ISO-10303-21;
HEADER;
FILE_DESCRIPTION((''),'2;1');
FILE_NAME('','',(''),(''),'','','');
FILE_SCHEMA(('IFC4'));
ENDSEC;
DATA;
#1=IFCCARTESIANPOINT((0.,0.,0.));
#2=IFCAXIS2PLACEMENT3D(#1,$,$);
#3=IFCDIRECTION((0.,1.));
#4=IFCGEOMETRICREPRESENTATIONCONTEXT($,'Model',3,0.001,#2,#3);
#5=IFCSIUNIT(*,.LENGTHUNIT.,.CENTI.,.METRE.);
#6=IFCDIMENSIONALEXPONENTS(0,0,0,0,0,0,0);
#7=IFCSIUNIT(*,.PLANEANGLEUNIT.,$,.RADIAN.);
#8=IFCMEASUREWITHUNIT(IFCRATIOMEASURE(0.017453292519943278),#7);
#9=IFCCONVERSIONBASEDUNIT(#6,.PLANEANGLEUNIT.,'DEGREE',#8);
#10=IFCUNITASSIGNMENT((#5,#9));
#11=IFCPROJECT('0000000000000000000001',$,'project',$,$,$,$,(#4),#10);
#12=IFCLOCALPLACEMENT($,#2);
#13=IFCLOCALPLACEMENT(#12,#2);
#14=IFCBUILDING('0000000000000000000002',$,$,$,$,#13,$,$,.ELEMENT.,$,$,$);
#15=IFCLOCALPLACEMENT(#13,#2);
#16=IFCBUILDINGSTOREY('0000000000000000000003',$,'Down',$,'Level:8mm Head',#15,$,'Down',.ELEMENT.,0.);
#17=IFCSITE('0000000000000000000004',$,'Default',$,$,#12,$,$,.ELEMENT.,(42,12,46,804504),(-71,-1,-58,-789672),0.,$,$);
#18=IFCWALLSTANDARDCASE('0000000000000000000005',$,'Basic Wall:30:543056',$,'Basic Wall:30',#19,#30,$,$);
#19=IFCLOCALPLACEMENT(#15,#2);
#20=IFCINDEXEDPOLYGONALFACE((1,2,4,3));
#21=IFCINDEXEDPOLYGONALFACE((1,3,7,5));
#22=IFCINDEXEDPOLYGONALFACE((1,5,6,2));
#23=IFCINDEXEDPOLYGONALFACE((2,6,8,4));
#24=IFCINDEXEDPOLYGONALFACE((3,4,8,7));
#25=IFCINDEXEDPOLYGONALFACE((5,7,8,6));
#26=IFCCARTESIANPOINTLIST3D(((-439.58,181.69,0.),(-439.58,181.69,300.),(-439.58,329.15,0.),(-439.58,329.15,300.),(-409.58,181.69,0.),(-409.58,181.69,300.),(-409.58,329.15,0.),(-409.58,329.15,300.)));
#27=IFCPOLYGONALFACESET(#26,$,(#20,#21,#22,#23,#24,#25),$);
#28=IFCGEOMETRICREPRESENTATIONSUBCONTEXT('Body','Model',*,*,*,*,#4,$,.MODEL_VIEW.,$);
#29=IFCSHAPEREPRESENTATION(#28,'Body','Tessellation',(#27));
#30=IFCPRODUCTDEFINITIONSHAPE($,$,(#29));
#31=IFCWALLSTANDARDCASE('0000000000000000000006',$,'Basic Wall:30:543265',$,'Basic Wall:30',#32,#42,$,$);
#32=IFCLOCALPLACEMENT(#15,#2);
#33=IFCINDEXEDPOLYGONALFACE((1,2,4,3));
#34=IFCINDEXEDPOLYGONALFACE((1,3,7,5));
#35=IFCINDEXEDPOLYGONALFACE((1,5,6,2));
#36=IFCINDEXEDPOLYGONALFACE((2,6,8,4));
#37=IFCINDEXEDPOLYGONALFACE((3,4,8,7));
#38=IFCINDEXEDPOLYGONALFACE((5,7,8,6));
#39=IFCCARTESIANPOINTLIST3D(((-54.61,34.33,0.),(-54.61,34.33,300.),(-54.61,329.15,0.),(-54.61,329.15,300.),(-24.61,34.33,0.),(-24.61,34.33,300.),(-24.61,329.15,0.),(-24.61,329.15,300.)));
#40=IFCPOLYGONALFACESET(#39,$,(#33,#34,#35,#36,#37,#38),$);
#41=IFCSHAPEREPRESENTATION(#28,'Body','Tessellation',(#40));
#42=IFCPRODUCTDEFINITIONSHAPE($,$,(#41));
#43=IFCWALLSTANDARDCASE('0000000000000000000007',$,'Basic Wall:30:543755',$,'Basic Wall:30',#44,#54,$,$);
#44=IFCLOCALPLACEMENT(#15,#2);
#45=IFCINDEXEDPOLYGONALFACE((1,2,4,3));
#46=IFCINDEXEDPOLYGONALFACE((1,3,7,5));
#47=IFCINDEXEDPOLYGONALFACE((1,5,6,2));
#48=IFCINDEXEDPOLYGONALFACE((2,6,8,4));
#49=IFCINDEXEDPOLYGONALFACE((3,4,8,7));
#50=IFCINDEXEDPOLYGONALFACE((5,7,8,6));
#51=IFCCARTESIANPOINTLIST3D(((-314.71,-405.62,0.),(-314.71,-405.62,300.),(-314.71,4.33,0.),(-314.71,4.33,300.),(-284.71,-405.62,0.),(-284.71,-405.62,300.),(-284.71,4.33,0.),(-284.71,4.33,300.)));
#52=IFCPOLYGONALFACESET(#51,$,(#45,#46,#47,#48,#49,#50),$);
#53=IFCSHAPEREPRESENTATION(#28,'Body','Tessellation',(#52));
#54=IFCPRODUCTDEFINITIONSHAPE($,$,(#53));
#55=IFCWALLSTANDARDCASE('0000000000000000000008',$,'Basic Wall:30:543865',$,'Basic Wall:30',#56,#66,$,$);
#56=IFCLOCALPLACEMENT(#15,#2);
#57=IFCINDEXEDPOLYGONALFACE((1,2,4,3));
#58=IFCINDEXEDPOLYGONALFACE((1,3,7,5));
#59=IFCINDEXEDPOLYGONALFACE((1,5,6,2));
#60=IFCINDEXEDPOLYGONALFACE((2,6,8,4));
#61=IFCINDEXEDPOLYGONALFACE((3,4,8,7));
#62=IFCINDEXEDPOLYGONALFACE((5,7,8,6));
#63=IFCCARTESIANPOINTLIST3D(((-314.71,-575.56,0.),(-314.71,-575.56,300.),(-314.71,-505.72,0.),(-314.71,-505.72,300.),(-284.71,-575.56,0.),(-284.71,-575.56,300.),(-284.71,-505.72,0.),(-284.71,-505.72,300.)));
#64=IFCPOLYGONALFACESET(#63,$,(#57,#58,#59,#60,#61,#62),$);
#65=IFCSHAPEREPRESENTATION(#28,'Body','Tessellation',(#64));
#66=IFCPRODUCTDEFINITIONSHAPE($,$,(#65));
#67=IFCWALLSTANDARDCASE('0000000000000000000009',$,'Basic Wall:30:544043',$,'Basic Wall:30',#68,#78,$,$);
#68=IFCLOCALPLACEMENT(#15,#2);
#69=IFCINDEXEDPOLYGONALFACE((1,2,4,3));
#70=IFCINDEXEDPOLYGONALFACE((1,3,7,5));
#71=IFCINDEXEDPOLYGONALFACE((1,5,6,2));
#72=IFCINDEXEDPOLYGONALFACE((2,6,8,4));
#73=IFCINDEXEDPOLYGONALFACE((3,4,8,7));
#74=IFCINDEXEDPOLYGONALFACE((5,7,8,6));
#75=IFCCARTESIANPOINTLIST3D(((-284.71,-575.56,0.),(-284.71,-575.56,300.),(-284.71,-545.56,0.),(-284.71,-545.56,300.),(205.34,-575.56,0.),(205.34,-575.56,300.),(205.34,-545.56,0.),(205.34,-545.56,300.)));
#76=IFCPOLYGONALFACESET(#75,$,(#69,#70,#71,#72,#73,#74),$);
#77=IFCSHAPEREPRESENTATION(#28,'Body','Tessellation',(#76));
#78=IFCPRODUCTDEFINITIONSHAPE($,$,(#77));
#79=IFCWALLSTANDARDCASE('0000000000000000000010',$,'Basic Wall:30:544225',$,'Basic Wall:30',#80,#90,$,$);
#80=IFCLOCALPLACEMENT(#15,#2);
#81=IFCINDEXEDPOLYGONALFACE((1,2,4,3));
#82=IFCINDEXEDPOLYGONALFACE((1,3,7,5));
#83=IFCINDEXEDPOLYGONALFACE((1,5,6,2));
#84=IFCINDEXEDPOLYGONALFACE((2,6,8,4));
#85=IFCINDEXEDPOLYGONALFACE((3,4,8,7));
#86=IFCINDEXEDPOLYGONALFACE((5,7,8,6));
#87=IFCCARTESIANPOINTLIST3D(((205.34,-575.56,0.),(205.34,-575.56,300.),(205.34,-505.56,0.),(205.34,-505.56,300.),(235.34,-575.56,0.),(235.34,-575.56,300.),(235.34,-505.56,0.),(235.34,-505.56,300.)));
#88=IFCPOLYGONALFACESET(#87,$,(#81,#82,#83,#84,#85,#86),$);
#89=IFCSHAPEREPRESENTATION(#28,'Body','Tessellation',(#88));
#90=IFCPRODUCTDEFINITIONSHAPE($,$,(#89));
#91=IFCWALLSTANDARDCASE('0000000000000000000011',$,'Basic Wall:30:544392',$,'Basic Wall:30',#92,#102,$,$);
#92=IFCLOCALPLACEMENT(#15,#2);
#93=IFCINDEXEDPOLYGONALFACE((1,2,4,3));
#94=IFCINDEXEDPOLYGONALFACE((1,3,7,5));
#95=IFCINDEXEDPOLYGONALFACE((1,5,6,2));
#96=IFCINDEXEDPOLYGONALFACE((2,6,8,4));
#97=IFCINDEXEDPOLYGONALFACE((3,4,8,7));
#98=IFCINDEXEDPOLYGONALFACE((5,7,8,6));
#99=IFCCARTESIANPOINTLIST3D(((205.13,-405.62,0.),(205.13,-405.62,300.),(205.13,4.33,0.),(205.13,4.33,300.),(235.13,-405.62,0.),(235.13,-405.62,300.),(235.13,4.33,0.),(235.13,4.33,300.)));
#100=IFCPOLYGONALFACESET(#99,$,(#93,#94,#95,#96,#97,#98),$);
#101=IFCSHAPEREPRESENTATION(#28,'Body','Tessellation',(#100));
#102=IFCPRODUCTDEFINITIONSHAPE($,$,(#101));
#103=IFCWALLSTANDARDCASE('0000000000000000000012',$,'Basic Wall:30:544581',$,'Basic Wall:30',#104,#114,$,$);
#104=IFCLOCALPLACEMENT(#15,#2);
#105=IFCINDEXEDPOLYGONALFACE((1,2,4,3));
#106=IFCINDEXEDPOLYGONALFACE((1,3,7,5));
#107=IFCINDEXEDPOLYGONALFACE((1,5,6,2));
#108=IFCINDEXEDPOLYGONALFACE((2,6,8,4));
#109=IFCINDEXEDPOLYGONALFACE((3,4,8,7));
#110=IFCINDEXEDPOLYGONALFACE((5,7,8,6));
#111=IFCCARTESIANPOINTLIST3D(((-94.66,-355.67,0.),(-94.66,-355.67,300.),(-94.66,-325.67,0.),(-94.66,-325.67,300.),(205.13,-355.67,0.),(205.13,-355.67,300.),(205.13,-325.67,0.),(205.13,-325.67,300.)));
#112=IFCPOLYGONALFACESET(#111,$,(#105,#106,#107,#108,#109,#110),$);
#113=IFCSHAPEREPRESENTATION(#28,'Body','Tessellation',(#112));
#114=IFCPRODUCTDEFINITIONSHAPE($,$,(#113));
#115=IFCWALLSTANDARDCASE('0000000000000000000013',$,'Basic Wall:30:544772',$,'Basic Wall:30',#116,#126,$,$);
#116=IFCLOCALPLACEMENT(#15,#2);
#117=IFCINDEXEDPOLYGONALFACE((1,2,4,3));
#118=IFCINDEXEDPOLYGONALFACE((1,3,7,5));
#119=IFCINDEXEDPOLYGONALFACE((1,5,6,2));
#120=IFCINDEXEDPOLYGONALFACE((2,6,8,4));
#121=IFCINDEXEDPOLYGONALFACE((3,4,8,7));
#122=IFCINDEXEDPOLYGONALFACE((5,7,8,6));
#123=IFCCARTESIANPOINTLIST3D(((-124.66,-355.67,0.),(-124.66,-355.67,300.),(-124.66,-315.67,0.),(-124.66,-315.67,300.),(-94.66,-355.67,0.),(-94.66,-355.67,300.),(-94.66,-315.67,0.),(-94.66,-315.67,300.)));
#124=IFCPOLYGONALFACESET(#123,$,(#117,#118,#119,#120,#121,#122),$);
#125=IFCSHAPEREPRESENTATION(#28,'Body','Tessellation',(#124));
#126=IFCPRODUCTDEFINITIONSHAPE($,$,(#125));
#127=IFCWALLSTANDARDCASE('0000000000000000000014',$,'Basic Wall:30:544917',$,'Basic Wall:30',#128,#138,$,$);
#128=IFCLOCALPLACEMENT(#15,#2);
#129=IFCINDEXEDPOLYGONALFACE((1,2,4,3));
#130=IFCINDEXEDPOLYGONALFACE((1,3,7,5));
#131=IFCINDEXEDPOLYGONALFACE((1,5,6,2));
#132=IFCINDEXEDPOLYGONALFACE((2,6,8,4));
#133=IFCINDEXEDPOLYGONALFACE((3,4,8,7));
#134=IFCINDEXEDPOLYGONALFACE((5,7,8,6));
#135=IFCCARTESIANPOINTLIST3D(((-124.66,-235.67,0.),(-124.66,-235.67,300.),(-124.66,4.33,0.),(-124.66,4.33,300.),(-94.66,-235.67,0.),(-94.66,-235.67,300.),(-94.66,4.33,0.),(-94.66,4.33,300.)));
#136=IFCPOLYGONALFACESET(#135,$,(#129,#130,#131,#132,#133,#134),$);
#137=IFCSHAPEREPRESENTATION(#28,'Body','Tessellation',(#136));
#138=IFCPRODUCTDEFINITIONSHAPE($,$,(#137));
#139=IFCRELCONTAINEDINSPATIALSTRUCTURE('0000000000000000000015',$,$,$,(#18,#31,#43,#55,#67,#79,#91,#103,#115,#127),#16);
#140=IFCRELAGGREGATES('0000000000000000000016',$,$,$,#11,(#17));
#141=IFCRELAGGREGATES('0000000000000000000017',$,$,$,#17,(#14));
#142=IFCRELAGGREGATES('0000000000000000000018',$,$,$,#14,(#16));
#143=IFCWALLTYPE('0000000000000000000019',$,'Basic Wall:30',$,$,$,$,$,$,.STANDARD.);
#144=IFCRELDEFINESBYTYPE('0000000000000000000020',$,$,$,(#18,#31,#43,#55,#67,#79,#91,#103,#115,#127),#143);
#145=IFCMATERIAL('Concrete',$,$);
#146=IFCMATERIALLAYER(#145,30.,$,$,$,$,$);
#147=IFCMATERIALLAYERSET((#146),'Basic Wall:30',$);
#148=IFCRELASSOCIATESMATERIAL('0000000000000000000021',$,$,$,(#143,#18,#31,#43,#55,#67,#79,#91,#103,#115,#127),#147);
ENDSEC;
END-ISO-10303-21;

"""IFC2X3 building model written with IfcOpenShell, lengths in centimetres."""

from ifc_helpers import new_model, entity, si_unit, converted_unit, direction, frame, frame_2d, origin, place, context, subcontext, project, spatial, rectangle, extrude, material, layer, layer_set, layer_usage, type_object, element, save


model = new_model("IFC2X3")

# Units and contexts
model_context = context("Model", 3, precision=0.001, world=origin(), true_north=direction((0.0, 1.0)))
body_context = subcontext(model_context, "Body", "Model", "MODEL_VIEW")
ifc_project = project(units=[si_unit("LENGTHUNIT", "METRE", prefix="CENTI"), converted_unit("PLANEANGLEUNIT", "DEGREE", entity("IfcRatioMeasure", 0.017453292519943278), si_unit("PLANEANGLEUNIT", "RADIAN"), dimensions=[0, 0, 0, 0, 0, 0, 0])], contexts=[model_context])

# Site, building, storey
site_placement = place(None, origin())
site = spatial("IfcSite", under=ifc_project, at=site_placement, Name="Default", CompositionType="ELEMENT", RefLatitude=(42, 12, 46, 804504), RefLongitude=(-71, -1, -58, -789672), RefElevation=0.0)
building_placement = place(site_placement, origin())
building = spatial("IfcBuilding", under=site, at=building_placement, CompositionType="ELEMENT")
storey_placement = place(building_placement, origin())
storey = spatial("IfcBuildingStorey", under=building, at=storey_placement, Name="Down", ObjectType="Level:8mm Head", LongName="Down", CompositionType="ELEMENT", Elevation=0.0)

# Shared definitions
ifc_material = material(Name="Concrete")

# Walls
ifc_layer_1 = layer(ifc_material, 30.0)
ifc_layer_set_1 = layer_set([ifc_layer_1], Name="Basic Wall:30")
wall_type_1 = type_object("IfcWallType", Name="Basic Wall:30", PredefinedType="STANDARD", material=ifc_layer_set_1)
ifc_layer_usage_1 = layer_usage(ifc_layer_set_1, "AXIS2", "NEGATIVE", 15.0)
wall_1_placement = place(storey_placement, frame((-424.58, 181.69, 0.0), z_axis=(0.0, 0.0, 1.0), x_axis=(0.0, 1.0, 0.0)))
element("IfcWallStandardCase", 1, at=wall_1_placement, inside=storey, type_object=wall_type_1, material=ifc_layer_usage_1, Name="Basic Wall:30:543056", ObjectType="Basic Wall:30", context=body_context, shape_type="SweptSolid", body=[
    extrude(rectangle(XDim=147.46, YDim=30.0, at=frame_2d((73.73, 0.0), x_axis=(-1.0, 0.0))), origin(), (0.0, 0.0, 1.0), 300.0),
])
ifc_layer_usage_2 = layer_usage(ifc_layer_set_1, "AXIS2", "NEGATIVE", 15.0)
wall_2_placement = place(storey_placement, frame((-39.61, 34.33, 0.0), z_axis=(0.0, 0.0, 1.0), x_axis=(0.0, 1.0, 0.0)))
element("IfcWallStandardCase", 2, at=wall_2_placement, inside=storey, type_object=wall_type_1, material=ifc_layer_usage_2, Name="Basic Wall:30:543265", ObjectType="Basic Wall:30", context=body_context, shape_type="SweptSolid", body=[
    extrude(rectangle(XDim=294.81, YDim=30.0, at=frame_2d((147.41, 0.0), x_axis=(-1.0, 0.0))), origin(), (0.0, 0.0, 1.0), 300.0),
])
ifc_layer_usage_3 = layer_usage(ifc_layer_set_1, "AXIS2", "POSITIVE", -15.0)
wall_3_placement = place(storey_placement, frame((-299.71, 4.33, 0.0), z_axis=(0.0, 0.0, 1.0), x_axis=(0.0, -1.0, 0.0)))
element("IfcWallStandardCase", 3, at=wall_3_placement, inside=storey, type_object=wall_type_1, material=ifc_layer_usage_3, Name="Basic Wall:30:543755", ObjectType="Basic Wall:30", context=body_context, shape_type="SweptSolid", body=[
    extrude(rectangle(XDim=409.95, YDim=30.0, at=frame_2d((204.97, 0.0), x_axis=(-1.0, 0.0))), origin(), (0.0, 0.0, 1.0), 300.0),
])
ifc_layer_usage_4 = layer_usage(ifc_layer_set_1, "AXIS2", "POSITIVE", -15.0)
wall_4_placement = place(storey_placement, frame((-299.71, -505.72, 0.0), z_axis=(0.0, 0.0, 1.0), x_axis=(0.0, -1.0, 0.0)))
element("IfcWallStandardCase", 4, at=wall_4_placement, inside=storey, type_object=wall_type_1, material=ifc_layer_usage_4, Name="Basic Wall:30:543865", ObjectType="Basic Wall:30", context=body_context, shape_type="SweptSolid", body=[
    extrude(rectangle(XDim=69.84, YDim=30.0, at=frame_2d((34.92, 0.0), x_axis=(-1.0, 0.0))), origin(), (0.0, 0.0, 1.0), 300.0),
])
ifc_layer_usage_5 = layer_usage(ifc_layer_set_1, "AXIS2", "POSITIVE", -15.0)
wall_5_placement = place(storey_placement, frame((-284.71, -560.56, 0.0)))
element("IfcWallStandardCase", 5, at=wall_5_placement, inside=storey, type_object=wall_type_1, material=ifc_layer_usage_5, Name="Basic Wall:30:544043", ObjectType="Basic Wall:30", context=body_context, shape_type="SweptSolid", body=[
    extrude(rectangle(XDim=490.05, YDim=30.0, at=frame_2d((245.03, 0.0), x_axis=(-1.0, 0.0))), origin(), (0.0, 0.0, 1.0), 300.0),
])
ifc_layer_usage_6 = layer_usage(ifc_layer_set_1, "AXIS2", "POSITIVE", -15.0)
wall_6_placement = place(storey_placement, frame((220.34, -575.56, 0.0), z_axis=(0.0, 0.0, 1.0), x_axis=(0.0, 1.0, 0.0)))
element("IfcWallStandardCase", 6, at=wall_6_placement, inside=storey, type_object=wall_type_1, material=ifc_layer_usage_6, Name="Basic Wall:30:544225", ObjectType="Basic Wall:30", context=body_context, shape_type="SweptSolid", body=[
    extrude(rectangle(XDim=70.0, YDim=30.0, at=frame_2d((35.0, 0.0), x_axis=(-1.0, 0.0))), origin(), (0.0, 0.0, 1.0), 300.0),
])
ifc_layer_usage_7 = layer_usage(ifc_layer_set_1, "AXIS2", "POSITIVE", -15.0)
wall_7_placement = place(storey_placement, frame((220.13, -405.62, 0.0), z_axis=(0.0, 0.0, 1.0), x_axis=(0.0, 1.0, 0.0)))
element("IfcWallStandardCase", 7, at=wall_7_placement, inside=storey, type_object=wall_type_1, material=ifc_layer_usage_7, Name="Basic Wall:30:544392", ObjectType="Basic Wall:30", context=body_context, shape_type="SweptSolid", body=[
    extrude(rectangle(XDim=409.95, YDim=30.0, at=frame_2d((204.97, 0.0), x_axis=(-1.0, 0.0))), origin(), (0.0, 0.0, 1.0), 300.0),
])
ifc_layer_usage_8 = layer_usage(ifc_layer_set_1, "AXIS2", "NEGATIVE", 15.0)
wall_8_placement = place(storey_placement, frame((205.13, -340.67, 0.0), z_axis=(0.0, 0.0, 1.0), x_axis=(-1.0, 0.0, 0.0)))
element("IfcWallStandardCase", 8, at=wall_8_placement, inside=storey, type_object=wall_type_1, material=ifc_layer_usage_8, Name="Basic Wall:30:544581", ObjectType="Basic Wall:30", context=body_context, shape_type="SweptSolid", body=[
    extrude(rectangle(XDim=299.79, YDim=30.0, at=frame_2d((149.89, 0.0), x_axis=(-1.0, 0.0))), origin(), (0.0, 0.0, 1.0), 300.0),
])
ifc_layer_usage_9 = layer_usage(ifc_layer_set_1, "AXIS2", "NEGATIVE", 15.0)
wall_9_placement = place(storey_placement, frame((-109.66, -355.67, 0.0), z_axis=(0.0, 0.0, 1.0), x_axis=(0.0, 1.0, 0.0)))
element("IfcWallStandardCase", 9, at=wall_9_placement, inside=storey, type_object=wall_type_1, material=ifc_layer_usage_9, Name="Basic Wall:30:544772", ObjectType="Basic Wall:30", context=body_context, shape_type="SweptSolid", body=[
    extrude(rectangle(XDim=40.0, YDim=30.0, at=frame_2d((20.0, 0.0), x_axis=(-1.0, 0.0))), origin(), (0.0, 0.0, 1.0), 300.0),
])
ifc_layer_usage_10 = layer_usage(ifc_layer_set_1, "AXIS2", "NEGATIVE", 15.0)
wall_10_placement = place(storey_placement, frame((-109.66, -235.67, 0.0), z_axis=(0.0, 0.0, 1.0), x_axis=(0.0, 1.0, 0.0)))
element("IfcWallStandardCase", 10, at=wall_10_placement, inside=storey, type_object=wall_type_1, material=ifc_layer_usage_10, Name="Basic Wall:30:544917", ObjectType="Basic Wall:30", context=body_context, shape_type="SweptSolid", body=[
    extrude(rectangle(XDim=240.0, YDim=30.0, at=frame_2d((120.0, 0.0), x_axis=(-1.0, 0.0))), origin(), (0.0, 0.0, 1.0), 300.0),
])

save(model, "model.ifc")
